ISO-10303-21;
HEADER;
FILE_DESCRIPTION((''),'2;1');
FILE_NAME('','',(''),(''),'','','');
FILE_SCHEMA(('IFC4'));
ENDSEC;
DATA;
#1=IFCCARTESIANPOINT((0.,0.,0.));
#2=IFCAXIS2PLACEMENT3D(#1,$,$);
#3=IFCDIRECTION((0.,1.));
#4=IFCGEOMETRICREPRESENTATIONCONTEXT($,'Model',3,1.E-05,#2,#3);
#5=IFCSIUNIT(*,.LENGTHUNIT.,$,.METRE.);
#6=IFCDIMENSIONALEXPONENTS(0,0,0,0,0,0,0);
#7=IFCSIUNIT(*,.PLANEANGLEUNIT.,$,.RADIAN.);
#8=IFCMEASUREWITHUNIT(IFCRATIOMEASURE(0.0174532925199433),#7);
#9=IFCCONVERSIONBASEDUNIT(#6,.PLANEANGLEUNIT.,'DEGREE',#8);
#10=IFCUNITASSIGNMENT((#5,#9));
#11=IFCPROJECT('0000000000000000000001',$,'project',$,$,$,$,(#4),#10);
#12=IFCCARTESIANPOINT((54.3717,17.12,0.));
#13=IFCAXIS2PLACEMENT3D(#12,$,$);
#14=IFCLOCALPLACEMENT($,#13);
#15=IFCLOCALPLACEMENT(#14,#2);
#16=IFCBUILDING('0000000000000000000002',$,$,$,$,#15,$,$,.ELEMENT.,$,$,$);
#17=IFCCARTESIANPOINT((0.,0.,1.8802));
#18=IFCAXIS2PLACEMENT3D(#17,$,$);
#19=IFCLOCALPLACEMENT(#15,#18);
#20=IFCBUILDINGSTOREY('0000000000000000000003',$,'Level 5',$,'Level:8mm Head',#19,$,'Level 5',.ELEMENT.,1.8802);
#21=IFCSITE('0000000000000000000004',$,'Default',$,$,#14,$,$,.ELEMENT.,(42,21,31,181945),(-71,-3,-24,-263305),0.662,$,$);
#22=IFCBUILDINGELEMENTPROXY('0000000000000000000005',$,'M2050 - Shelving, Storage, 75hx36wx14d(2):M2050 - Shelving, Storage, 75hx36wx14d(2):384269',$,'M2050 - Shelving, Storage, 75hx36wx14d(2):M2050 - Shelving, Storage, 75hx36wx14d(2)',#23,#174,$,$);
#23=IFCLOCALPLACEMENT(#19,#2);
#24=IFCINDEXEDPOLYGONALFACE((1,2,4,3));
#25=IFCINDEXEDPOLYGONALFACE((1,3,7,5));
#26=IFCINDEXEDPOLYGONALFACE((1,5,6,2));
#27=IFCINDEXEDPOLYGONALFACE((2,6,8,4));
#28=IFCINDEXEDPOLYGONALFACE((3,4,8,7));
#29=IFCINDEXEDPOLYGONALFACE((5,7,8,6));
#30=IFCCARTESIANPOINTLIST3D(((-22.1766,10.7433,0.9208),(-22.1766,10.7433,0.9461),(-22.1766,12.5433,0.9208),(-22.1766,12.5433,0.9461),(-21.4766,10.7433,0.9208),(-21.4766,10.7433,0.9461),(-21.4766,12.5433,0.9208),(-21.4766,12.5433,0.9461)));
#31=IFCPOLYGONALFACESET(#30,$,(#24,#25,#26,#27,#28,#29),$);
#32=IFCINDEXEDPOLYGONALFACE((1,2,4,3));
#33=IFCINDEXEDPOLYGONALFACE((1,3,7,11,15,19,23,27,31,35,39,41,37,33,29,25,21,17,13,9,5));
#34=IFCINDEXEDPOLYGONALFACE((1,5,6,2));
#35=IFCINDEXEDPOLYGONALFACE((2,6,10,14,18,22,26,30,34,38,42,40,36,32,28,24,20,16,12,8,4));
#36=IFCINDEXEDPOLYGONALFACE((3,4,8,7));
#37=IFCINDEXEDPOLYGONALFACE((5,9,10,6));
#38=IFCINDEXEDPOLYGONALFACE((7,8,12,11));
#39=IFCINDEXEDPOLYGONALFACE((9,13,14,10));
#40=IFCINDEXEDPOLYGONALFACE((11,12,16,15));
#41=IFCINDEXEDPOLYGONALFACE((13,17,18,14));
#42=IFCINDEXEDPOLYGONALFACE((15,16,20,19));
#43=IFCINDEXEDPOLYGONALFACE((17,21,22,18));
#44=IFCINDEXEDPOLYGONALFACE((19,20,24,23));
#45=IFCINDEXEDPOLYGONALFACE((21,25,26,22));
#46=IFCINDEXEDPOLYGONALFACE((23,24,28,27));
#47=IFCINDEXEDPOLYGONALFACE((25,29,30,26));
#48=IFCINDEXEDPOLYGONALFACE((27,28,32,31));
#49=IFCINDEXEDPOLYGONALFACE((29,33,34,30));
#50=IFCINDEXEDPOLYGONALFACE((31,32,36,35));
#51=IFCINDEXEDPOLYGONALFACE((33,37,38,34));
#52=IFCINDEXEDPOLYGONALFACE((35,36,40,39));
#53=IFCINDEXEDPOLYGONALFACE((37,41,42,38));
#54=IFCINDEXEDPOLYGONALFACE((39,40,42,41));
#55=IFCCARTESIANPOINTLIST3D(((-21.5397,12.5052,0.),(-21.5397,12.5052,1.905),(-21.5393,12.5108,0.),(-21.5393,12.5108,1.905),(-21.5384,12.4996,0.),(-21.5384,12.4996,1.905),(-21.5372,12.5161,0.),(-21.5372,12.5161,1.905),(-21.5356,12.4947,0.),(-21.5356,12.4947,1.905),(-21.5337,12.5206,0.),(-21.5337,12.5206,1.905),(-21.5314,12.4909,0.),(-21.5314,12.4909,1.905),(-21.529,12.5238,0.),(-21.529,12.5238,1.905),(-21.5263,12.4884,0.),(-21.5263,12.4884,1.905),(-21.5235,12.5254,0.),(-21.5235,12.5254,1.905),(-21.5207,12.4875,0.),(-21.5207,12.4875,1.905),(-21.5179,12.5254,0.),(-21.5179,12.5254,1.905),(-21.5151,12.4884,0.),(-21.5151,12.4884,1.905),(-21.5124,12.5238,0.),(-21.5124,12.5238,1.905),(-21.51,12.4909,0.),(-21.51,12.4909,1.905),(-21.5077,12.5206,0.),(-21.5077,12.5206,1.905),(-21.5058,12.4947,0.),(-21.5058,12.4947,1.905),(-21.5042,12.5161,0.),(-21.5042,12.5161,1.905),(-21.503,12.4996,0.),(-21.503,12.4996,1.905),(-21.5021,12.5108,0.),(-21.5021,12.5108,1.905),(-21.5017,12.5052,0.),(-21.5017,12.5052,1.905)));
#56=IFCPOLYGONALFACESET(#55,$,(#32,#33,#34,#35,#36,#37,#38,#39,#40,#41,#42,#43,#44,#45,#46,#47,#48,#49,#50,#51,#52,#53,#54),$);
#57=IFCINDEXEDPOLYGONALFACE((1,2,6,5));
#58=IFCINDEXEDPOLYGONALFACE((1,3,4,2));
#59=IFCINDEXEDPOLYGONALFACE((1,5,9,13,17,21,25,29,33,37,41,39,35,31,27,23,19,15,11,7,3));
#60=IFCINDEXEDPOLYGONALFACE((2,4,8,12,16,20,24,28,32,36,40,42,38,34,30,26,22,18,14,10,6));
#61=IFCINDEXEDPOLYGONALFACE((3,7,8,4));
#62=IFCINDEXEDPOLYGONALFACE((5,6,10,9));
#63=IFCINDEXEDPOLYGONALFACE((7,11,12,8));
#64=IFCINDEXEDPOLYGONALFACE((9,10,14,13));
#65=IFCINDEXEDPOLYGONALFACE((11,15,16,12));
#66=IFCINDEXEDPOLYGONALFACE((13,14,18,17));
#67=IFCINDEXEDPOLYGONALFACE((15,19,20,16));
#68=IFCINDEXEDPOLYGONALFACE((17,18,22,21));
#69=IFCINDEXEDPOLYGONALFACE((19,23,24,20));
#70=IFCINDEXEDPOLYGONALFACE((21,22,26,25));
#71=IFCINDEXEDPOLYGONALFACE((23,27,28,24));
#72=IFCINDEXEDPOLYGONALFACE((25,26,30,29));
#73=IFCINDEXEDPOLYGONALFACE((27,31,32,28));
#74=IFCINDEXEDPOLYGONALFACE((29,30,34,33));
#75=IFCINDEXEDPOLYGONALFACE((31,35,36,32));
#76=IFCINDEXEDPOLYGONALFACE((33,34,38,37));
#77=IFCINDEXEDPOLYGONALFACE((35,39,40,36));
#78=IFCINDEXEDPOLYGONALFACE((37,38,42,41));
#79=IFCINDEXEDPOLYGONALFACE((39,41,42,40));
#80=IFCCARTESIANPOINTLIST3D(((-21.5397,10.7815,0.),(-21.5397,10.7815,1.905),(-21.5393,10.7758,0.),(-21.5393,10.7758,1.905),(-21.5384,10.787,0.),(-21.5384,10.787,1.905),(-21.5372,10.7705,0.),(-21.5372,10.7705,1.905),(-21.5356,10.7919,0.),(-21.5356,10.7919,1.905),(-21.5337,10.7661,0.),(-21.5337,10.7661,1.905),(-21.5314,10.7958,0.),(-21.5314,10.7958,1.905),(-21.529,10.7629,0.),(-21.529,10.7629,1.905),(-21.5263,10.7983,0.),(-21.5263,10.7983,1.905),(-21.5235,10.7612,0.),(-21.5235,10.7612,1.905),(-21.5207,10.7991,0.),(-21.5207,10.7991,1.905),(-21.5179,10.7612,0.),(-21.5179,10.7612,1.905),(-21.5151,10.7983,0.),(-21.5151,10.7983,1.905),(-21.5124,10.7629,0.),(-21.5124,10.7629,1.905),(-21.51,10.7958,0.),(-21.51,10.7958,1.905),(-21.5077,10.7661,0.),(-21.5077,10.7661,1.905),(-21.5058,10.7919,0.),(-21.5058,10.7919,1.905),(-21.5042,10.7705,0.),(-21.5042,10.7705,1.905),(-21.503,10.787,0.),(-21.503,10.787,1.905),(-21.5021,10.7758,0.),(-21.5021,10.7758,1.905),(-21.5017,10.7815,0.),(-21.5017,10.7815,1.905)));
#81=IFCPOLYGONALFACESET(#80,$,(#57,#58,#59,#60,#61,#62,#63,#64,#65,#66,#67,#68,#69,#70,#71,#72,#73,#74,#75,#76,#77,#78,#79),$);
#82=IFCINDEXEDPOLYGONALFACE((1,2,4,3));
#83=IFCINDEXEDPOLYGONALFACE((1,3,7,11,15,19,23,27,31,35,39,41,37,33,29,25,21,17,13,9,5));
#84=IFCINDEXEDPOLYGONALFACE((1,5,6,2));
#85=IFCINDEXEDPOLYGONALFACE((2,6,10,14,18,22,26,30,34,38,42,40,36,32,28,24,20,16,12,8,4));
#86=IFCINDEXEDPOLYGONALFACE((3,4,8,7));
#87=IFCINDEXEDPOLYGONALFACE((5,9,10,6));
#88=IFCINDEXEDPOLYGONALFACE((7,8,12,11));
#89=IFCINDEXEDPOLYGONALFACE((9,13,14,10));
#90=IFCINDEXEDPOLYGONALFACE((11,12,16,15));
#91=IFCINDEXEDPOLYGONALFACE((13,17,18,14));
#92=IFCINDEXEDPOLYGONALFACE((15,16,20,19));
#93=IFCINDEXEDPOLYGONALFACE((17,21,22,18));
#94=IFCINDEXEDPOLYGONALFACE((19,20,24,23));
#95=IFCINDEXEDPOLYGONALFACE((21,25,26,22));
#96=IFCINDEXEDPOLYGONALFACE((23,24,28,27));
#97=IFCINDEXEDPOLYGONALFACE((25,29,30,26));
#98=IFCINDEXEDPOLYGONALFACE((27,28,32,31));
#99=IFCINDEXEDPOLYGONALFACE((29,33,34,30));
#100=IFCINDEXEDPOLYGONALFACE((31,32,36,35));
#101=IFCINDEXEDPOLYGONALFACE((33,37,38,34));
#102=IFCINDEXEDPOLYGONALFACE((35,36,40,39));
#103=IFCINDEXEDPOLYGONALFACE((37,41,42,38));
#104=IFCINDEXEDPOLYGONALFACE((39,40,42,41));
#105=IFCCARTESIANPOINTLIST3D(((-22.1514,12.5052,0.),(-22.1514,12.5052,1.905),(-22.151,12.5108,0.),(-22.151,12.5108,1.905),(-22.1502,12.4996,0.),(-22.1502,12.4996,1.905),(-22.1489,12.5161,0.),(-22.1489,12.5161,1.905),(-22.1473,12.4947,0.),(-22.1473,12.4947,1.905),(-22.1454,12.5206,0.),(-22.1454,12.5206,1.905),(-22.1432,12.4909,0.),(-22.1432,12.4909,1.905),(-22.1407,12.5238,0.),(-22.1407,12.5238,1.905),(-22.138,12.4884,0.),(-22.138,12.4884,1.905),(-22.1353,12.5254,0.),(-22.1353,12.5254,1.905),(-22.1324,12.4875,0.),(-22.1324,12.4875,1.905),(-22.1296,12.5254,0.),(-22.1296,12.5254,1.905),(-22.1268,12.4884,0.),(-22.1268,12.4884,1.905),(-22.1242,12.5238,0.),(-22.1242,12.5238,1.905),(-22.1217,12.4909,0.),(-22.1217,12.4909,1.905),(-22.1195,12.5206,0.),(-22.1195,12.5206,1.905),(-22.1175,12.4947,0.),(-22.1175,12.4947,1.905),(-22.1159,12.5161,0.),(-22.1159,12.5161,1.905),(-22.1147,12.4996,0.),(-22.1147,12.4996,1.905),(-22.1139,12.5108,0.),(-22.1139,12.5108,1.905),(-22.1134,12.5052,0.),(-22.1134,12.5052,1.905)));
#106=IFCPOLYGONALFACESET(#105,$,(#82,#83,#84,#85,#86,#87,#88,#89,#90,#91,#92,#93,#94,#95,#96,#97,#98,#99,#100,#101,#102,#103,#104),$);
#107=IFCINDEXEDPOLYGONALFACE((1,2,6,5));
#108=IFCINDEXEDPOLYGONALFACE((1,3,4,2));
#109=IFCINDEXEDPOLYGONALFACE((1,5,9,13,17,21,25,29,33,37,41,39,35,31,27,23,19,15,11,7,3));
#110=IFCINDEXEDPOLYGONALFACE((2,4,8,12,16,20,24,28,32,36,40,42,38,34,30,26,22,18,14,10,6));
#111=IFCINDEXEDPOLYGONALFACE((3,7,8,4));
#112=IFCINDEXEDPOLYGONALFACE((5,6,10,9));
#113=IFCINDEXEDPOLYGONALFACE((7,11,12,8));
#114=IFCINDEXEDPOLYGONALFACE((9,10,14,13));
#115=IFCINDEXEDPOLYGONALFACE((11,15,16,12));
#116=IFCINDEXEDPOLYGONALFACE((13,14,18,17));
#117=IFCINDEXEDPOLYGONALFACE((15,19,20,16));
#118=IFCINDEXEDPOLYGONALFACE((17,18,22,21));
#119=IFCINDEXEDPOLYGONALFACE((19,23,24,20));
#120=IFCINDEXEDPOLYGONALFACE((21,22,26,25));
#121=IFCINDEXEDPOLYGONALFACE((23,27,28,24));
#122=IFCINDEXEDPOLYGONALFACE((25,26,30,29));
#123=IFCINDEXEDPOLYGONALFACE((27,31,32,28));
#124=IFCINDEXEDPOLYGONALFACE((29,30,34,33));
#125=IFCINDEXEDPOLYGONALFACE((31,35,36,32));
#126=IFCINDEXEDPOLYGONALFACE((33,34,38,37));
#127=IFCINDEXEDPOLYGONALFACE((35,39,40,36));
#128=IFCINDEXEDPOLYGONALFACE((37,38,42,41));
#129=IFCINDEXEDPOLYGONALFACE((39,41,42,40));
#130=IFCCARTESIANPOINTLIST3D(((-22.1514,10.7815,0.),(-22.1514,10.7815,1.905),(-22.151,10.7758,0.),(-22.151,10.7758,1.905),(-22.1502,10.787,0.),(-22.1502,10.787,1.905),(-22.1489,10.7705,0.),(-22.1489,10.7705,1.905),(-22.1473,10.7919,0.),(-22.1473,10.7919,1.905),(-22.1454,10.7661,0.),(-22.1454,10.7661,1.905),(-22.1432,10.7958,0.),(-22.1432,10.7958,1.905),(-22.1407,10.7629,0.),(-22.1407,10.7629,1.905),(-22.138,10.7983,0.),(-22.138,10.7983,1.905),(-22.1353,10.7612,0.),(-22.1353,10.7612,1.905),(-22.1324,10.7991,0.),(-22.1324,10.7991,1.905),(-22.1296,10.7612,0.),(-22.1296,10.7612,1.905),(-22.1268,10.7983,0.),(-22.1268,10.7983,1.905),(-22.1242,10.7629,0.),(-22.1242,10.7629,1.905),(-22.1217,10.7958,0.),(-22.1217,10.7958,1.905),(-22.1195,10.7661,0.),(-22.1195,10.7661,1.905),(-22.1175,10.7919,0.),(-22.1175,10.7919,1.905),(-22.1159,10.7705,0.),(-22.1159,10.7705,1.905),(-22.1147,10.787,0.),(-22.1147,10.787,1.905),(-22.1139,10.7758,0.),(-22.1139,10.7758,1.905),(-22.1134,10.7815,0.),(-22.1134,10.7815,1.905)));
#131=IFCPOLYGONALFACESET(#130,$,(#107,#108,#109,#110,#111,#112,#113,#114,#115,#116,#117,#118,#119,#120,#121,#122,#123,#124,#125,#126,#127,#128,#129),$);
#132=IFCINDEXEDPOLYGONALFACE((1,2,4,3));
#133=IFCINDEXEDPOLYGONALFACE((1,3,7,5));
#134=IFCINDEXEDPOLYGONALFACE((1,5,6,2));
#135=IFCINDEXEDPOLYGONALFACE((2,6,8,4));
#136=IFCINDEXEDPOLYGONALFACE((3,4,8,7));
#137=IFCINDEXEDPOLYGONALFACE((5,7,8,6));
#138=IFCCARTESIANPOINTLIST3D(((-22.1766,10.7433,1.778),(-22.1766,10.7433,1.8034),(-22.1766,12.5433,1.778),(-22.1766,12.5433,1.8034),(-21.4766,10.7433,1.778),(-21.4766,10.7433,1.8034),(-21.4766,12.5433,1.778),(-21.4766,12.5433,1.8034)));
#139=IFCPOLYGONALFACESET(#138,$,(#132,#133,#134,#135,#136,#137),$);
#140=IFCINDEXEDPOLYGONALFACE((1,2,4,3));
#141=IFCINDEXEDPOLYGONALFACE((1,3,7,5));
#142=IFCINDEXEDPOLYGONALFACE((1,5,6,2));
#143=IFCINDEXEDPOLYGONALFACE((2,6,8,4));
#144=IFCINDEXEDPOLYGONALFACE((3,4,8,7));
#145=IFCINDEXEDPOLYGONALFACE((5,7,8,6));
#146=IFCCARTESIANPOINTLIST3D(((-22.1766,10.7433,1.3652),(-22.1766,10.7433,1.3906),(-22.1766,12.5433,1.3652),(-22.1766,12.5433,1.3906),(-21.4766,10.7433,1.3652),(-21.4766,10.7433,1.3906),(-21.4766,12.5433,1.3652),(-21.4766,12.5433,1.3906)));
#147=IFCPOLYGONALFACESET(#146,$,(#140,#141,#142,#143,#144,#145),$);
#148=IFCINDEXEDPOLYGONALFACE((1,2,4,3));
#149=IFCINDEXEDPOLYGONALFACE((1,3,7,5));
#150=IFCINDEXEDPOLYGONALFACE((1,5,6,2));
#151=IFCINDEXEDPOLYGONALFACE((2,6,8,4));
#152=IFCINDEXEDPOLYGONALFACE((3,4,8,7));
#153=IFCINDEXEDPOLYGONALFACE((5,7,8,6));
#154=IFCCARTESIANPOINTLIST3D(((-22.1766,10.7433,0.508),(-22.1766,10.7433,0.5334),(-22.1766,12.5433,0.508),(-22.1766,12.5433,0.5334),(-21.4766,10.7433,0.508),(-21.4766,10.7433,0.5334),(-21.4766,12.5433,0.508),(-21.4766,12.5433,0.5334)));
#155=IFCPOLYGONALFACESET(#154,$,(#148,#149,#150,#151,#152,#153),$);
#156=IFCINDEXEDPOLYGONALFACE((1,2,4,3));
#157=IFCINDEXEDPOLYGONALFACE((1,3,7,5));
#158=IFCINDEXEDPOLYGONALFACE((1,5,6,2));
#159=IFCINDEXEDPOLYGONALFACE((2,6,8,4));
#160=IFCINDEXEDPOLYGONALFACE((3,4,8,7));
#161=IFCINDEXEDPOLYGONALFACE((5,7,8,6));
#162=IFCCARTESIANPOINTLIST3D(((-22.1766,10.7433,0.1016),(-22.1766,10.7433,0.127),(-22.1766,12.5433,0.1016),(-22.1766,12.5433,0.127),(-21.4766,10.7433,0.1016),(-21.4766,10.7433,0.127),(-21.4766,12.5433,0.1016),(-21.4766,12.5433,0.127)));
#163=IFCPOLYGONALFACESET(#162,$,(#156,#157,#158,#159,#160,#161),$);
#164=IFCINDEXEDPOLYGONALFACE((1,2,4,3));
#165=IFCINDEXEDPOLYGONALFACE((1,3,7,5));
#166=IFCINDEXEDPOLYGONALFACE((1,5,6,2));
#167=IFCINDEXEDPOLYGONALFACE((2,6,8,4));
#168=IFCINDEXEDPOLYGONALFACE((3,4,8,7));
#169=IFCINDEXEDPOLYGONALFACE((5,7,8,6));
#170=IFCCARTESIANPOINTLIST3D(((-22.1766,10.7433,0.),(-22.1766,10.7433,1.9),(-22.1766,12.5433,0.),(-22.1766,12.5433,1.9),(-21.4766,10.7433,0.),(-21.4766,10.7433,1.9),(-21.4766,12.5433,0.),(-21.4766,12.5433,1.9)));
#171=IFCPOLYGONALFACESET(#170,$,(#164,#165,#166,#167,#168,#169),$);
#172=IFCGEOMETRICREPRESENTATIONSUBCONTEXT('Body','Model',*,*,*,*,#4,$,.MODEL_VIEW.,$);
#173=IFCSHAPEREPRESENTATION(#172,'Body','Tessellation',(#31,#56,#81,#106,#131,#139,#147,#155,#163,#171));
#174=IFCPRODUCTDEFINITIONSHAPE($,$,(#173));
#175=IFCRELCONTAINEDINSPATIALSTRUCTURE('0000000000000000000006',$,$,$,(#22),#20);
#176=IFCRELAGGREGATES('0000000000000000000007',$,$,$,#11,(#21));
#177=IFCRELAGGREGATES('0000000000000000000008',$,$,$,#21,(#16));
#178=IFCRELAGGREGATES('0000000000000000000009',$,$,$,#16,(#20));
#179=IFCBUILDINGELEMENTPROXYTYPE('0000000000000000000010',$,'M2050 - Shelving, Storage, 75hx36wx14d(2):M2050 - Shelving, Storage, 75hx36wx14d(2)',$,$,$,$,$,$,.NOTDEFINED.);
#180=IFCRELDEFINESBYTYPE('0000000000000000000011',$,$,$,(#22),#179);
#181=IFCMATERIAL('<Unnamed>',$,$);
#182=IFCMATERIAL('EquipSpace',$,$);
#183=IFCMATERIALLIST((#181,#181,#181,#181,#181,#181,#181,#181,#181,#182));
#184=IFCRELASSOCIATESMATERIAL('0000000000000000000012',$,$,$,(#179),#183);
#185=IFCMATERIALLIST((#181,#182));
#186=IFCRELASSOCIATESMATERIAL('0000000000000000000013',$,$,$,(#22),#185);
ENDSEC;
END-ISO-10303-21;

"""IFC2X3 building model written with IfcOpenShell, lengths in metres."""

from ifc_helpers import new_model, entity, si_unit, converted_unit, direction, frame, frame_2d, origin, origin_2d_with_axis, place, context, subcontext, project, spatial, rectangle, circle, extrude, source, transform, mapped, material, material_list, type_object, type_shapes, element, save


model = new_model("IFC2X3")

# Units and contexts
model_context = context("Model", 3, precision=1e-05, world=origin(), true_north=direction((0.0, 1.0)))
body_context = subcontext(model_context, "Body", "Model", "MODEL_VIEW")
ifc_project = project(units=[si_unit("LENGTHUNIT", "METRE"), converted_unit("PLANEANGLEUNIT", "DEGREE", entity("IfcRatioMeasure", 0.0174532925199433), si_unit("PLANEANGLEUNIT", "RADIAN"), dimensions=[0, 0, 0, 0, 0, 0, 0])], contexts=[model_context])

# Site, building, storey
site_placement = place(None, frame((54.3717, 17.12, 0.0)))
site = spatial("IfcSite", under=ifc_project, at=site_placement, Name="Default", CompositionType="ELEMENT", RefLatitude=(42, 21, 31, 181945), RefLongitude=(-71, -3, -24, -263305), RefElevation=0.662)
building_placement = place(site_placement, origin())
building = spatial("IfcBuilding", under=site, at=building_placement, CompositionType="ELEMENT")
storey_placement = place(building_placement, frame((0.0, 0.0, 1.8802)))
storey = spatial("IfcBuildingStorey", under=building, at=storey_placement, Name="Level 5", ObjectType="Level:8mm Head", LongName="Level 5", CompositionType="ELEMENT", Elevation=1.8802)

# Building element proxy
ifc_material_1 = material(Name="<Unnamed>")
ifc_material_2 = material(Name="EquipSpace")
ifc_material_list_1 = material_list([ifc_material_1, ifc_material_1, ifc_material_1, ifc_material_1, ifc_material_1, ifc_material_1, ifc_material_1, ifc_material_1, ifc_material_1, ifc_material_2])
building_element_proxy_type = type_object("IfcBuildingElementProxyType", Name="M2050 - Shelving, Storage, 75hx36wx14d(2):M2050 - Shelving, Storage, 75hx36wx14d(2)", PredefinedType="NOTDEFINED", material=ifc_material_list_1)
shared_shape = source(origin(), body_context, "Body", "SweptSolid", [
    extrude(rectangle(XDim=1.8, YDim=0.7, at=origin_2d_with_axis()), frame((0.0, 0.0, 0.9207), z_axis=(0.0, 0.0, 1.0), x_axis=(-1.0, 0.0, 0.0)), (0.0, 0.0, 1.0), 0.0254),
    extrude(circle(Radius=0.0191, at=origin_2d_with_axis()), frame((0.8633, -0.3059, 0.0), z_axis=(0.0, 0.0, 1.0), x_axis=(-1.0, 0.0, 0.0)), (0.0, 0.0, 1.0), 1.905),
    extrude(circle(Radius=0.0191, at=origin_2d_with_axis()), frame((-0.8633, -0.3059, 0.0)), (0.0, 0.0, 1.0), 1.905),
    extrude(circle(Radius=0.0191, at=origin_2d_with_axis()), frame((0.8633, 0.3059, 0.0), z_axis=(0.0, 0.0, 1.0), x_axis=(-1.0, 0.0, 0.0)), (0.0, 0.0, 1.0), 1.905),
    extrude(circle(Radius=0.0191, at=origin_2d_with_axis()), frame((-0.8633, 0.3059, 0.0)), (0.0, 0.0, 1.0), 1.905),
    extrude(rectangle(XDim=1.8, YDim=0.7, at=origin_2d_with_axis()), frame((0.0, 0.0, 1.778), z_axis=(0.0, 0.0, 1.0), x_axis=(-1.0, 0.0, 0.0)), (0.0, 0.0, 1.0), 0.0254),
    extrude(rectangle(XDim=1.8, YDim=0.7, at=origin_2d_with_axis()), frame((0.0, 0.0, 1.3653), z_axis=(0.0, 0.0, 1.0), x_axis=(-1.0, 0.0, 0.0)), (0.0, 0.0, 1.0), 0.0254),
    extrude(rectangle(XDim=1.8, YDim=0.7, at=origin_2d_with_axis()), frame((0.0, 0.0, 0.508), z_axis=(0.0, 0.0, 1.0), x_axis=(-1.0, 0.0, 0.0)), (0.0, 0.0, 1.0), 0.0254),
    extrude(rectangle(XDim=1.8, YDim=0.7, at=origin_2d_with_axis()), frame((0.0, 0.0, 0.1016), z_axis=(0.0, 0.0, 1.0), x_axis=(-1.0, 0.0, 0.0)), (0.0, 0.0, 1.0), 0.0254),
    extrude(rectangle(XDim=0.7, YDim=1.8, at=frame_2d((0.0, 0.18), x_axis=(1.0, 0.0))), frame((-0.18, 0.0, 0.0), z_axis=(0.0, 0.0, 1.0), x_axis=(0.0, -1.0, 0.0)), (0.0, 0.0, 1.0), 1.9),
])
type_shapes(building_element_proxy_type, [shared_shape])
ifc_material_list_2 = material_list([ifc_material_1, ifc_material_2])
proxy_1_placement = place(storey_placement, frame((-21.8266, 11.6433, 0.0), z_axis=(0.0, 0.0, 1.0), x_axis=(0.0, 1.0, 0.0)))
element("IfcBuildingElementProxy", 1, at=proxy_1_placement, inside=storey, type_object=building_element_proxy_type, material=ifc_material_list_2, Name="M2050 - Shelving, Storage, 75hx36wx14d(2):M2050 - Shelving, Storage, 75hx36wx14d(2):384269", ObjectType="M2050 - Shelving, Storage, 75hx36wx14d(2):M2050 - Shelving, Storage, 75hx36wx14d(2)", context=body_context, shape_type="MappedRepresentation", body=[
    mapped(shared_shape, transform((0.0, 0.0, 0.0), scale=1.0)),
])

save(model, "model.ifc")
